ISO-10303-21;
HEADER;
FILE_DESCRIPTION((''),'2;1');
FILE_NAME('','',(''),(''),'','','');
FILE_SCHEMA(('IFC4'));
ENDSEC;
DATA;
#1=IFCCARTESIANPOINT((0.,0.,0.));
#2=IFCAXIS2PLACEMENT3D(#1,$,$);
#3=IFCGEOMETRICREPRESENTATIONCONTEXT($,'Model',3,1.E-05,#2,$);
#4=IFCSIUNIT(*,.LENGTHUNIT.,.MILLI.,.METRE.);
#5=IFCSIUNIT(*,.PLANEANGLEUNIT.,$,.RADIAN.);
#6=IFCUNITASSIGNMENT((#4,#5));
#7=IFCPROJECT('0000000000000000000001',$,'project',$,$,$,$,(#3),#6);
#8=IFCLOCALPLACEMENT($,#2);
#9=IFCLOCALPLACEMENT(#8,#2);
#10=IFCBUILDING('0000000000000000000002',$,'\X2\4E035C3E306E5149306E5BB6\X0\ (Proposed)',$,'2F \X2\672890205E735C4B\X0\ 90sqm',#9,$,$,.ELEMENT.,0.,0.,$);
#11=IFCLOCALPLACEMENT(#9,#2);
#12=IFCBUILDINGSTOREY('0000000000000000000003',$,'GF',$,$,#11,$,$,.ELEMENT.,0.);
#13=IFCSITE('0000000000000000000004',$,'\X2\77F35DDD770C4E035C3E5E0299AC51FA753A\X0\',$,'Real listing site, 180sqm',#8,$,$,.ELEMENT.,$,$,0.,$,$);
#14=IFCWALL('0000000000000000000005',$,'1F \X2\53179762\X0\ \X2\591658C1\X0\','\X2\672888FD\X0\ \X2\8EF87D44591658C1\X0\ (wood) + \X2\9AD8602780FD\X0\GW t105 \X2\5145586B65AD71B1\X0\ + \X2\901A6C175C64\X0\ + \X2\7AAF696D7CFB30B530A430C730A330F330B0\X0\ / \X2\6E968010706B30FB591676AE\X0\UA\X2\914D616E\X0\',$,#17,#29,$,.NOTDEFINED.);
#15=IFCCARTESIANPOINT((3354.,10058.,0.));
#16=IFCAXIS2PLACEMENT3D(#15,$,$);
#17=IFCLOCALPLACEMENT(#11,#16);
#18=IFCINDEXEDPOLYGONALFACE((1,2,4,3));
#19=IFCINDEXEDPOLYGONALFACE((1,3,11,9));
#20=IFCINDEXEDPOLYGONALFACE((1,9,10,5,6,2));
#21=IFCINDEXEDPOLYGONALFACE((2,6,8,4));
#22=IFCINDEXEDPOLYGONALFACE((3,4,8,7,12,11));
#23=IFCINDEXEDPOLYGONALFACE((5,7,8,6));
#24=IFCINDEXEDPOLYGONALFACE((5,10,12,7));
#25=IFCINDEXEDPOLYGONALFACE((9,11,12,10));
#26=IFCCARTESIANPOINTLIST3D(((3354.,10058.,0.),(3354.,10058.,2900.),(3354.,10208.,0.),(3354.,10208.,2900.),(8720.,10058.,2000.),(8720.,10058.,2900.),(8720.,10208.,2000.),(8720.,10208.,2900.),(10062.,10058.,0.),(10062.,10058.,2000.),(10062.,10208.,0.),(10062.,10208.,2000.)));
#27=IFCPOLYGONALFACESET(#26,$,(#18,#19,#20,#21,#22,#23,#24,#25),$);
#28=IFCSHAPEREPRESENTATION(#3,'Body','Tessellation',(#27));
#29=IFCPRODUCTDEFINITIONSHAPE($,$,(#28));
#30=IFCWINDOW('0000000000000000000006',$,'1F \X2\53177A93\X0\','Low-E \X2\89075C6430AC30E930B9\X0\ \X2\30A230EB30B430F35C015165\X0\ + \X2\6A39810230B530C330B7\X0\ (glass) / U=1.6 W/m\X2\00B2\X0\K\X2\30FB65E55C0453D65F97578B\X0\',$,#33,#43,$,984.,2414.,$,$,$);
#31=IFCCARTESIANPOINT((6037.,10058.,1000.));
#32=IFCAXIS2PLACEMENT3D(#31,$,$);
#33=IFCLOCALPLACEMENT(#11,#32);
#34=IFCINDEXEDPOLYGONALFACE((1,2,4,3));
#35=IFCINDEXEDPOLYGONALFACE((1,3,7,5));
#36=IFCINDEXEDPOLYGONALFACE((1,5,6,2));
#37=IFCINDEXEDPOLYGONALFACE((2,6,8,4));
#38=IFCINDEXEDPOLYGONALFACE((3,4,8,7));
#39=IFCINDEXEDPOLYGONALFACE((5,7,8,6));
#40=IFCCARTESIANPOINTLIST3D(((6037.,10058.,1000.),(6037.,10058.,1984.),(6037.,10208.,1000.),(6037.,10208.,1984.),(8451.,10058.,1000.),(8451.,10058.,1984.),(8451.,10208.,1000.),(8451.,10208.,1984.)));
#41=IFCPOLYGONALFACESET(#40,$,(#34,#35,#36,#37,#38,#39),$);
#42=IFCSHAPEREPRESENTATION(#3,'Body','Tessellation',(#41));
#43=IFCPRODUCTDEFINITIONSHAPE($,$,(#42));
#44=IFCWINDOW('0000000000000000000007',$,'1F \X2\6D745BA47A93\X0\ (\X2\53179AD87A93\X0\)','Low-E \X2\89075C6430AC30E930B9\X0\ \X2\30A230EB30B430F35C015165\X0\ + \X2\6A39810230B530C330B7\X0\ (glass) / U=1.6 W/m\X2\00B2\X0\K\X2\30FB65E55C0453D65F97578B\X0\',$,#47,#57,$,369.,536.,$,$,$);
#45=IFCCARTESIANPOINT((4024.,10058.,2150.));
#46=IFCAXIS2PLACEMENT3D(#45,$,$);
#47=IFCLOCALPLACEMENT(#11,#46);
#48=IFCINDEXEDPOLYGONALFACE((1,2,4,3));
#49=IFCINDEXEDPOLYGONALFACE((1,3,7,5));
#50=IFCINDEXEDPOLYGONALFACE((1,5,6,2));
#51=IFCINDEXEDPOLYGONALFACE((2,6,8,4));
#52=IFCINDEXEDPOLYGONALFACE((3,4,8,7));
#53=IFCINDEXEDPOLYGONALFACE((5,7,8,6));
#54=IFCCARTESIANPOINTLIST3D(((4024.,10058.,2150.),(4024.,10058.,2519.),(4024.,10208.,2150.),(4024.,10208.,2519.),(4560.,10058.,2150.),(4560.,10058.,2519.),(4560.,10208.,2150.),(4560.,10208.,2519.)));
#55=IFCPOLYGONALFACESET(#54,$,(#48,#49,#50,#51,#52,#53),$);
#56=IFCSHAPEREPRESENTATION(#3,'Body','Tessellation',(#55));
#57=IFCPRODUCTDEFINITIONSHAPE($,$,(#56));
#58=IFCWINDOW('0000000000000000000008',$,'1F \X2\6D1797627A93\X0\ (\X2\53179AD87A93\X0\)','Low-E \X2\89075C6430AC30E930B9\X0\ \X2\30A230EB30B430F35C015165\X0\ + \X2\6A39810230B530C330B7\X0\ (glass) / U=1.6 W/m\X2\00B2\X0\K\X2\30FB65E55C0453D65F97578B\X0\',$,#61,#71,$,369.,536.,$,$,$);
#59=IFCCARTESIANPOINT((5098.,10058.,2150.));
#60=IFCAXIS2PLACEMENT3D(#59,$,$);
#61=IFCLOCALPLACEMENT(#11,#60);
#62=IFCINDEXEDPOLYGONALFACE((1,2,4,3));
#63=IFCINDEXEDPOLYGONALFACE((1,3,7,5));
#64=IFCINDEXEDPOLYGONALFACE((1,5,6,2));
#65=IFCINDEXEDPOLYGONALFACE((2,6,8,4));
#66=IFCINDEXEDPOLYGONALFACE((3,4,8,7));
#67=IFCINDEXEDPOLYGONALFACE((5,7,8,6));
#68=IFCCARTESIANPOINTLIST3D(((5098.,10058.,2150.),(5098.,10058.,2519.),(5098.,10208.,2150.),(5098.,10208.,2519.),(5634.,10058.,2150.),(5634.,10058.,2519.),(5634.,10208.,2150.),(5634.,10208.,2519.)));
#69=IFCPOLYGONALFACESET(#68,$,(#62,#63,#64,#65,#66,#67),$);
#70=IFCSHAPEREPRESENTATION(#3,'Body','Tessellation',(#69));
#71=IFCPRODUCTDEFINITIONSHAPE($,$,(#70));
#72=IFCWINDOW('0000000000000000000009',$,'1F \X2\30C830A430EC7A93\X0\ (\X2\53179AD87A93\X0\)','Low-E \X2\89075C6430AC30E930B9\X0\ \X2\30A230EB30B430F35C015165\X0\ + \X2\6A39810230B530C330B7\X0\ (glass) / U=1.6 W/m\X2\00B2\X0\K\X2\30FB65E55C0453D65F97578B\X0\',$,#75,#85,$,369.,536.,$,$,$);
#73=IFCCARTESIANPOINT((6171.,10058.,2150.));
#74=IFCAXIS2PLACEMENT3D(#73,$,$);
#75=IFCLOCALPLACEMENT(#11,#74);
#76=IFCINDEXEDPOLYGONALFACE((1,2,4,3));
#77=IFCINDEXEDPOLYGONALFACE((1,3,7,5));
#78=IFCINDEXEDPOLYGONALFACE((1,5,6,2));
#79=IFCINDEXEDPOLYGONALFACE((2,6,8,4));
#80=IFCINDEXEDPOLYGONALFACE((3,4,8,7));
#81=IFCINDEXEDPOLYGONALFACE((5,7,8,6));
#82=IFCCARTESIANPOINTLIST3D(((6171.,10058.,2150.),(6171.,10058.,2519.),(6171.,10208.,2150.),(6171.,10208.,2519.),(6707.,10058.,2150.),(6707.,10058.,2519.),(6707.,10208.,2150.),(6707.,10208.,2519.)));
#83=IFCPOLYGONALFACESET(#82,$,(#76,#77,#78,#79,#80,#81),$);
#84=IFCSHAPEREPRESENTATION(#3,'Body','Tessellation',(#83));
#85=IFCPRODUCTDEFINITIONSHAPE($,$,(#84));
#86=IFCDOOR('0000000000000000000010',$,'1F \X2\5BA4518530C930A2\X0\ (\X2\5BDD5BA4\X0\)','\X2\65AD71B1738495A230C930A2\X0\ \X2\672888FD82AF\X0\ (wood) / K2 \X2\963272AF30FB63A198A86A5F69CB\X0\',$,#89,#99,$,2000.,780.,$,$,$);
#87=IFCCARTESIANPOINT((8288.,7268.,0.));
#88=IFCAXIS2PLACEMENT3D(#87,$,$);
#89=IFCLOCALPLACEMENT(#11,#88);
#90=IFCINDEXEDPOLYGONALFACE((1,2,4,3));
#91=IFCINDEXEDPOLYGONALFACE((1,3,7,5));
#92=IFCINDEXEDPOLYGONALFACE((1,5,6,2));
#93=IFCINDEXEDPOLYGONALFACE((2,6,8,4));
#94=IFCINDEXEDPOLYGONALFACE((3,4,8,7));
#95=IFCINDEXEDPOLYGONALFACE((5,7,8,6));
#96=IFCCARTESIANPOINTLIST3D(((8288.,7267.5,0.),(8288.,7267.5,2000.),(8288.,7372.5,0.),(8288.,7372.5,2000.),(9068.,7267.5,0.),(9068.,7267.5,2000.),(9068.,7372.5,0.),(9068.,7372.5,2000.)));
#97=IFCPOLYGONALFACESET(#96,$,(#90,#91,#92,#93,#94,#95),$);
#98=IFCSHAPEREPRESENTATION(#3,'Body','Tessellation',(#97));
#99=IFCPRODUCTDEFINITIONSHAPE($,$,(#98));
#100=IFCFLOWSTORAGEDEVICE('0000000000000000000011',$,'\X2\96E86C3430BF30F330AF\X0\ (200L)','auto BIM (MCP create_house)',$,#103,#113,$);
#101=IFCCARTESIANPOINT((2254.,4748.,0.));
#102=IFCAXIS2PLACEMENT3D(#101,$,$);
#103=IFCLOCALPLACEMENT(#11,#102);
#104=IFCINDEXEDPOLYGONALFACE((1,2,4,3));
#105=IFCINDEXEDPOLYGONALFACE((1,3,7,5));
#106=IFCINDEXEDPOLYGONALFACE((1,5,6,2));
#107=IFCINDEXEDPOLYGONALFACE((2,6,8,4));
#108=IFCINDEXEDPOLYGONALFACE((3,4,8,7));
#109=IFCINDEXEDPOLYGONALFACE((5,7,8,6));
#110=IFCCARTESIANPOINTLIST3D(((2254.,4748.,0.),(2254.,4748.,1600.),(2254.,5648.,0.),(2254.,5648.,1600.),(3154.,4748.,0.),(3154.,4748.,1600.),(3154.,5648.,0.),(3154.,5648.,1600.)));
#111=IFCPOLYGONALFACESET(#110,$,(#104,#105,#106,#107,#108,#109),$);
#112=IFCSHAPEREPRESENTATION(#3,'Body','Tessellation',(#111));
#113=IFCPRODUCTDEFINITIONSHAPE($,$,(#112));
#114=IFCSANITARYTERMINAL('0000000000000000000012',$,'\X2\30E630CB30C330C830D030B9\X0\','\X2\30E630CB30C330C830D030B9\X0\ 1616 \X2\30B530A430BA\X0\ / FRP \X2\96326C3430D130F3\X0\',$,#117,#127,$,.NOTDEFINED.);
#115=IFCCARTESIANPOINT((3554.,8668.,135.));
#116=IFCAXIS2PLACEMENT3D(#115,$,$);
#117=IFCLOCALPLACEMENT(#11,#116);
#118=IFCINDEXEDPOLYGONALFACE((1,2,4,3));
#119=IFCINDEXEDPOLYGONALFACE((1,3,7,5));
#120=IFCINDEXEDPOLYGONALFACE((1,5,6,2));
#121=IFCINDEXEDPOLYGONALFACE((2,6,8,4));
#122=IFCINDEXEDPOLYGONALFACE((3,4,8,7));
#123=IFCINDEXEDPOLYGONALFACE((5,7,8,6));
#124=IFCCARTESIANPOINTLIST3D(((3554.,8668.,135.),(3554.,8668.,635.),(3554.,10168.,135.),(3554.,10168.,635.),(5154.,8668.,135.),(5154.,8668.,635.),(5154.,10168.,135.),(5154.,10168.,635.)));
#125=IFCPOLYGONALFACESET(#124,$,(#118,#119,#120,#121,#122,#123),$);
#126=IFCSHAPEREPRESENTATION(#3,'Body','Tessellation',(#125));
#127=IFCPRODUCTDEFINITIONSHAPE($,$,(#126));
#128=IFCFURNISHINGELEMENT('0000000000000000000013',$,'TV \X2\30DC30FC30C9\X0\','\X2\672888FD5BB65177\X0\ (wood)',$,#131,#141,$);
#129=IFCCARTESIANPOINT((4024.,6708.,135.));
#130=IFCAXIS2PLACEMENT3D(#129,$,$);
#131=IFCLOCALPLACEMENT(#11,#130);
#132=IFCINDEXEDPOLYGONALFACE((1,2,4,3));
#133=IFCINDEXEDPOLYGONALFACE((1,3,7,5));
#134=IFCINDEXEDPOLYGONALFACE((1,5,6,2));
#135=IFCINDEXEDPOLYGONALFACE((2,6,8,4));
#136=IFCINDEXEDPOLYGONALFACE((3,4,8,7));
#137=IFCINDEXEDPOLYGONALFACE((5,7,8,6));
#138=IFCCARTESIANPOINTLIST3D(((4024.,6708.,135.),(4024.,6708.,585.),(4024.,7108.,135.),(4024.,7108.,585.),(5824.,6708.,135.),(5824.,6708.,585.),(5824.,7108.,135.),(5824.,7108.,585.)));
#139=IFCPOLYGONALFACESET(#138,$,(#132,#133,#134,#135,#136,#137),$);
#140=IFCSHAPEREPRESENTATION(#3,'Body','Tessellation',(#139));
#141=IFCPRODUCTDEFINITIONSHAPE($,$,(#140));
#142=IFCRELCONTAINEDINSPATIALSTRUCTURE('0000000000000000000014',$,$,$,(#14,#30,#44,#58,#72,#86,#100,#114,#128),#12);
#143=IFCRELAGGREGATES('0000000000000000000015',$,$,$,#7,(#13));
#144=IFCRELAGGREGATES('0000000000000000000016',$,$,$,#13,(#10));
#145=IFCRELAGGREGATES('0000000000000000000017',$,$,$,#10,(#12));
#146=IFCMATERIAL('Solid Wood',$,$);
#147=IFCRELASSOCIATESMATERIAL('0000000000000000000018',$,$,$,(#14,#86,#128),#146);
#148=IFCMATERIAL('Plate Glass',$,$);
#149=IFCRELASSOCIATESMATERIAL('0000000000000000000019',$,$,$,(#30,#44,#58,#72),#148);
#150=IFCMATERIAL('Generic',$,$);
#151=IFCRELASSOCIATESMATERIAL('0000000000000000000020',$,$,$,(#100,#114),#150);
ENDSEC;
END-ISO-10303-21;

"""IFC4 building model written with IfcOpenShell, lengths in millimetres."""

from ifc_helpers import new_model, si_unit, frame, frame_2d, origin, place, context, project, spatial, rectangle, extrude, material, element, fill, save


model = new_model("IFC4")

# Units and contexts
model_context = context("Model", 3, precision=1e-05, world=origin())
ifc_project = project(units=[si_unit("LENGTHUNIT", "METRE", prefix="MILLI"), si_unit("PLANEANGLEUNIT", "RADIAN")], contexts=[model_context])

# Site, building, storey
site_placement = place(None, origin())
site = spatial("IfcSite", under=ifc_project, at=site_placement, Name="石川県七尾市馬出町", ObjectType="Real listing site, 180sqm", CompositionType="ELEMENT", RefElevation=0.0)
building_placement = place(site_placement, origin())
building = spatial("IfcBuilding", under=site, at=building_placement, Name="七尾の光の家 (Proposed)", ObjectType="2F 木造平屋 90sqm", CompositionType="ELEMENT", ElevationOfRefHeight=0.0, ElevationOfTerrain=0.0)
storey_placement = place(building_placement, origin())
storey = spatial("IfcBuildingStorey", under=building, at=storey_placement, Name="GF", CompositionType="ELEMENT", Elevation=0.0)

# Wall, openings, windows
ifc_material_1 = material(Name="Solid Wood")
wall_1_placement = place(storey_placement, frame((3354.0, 10058.0, 0.0)))
wall_1 = element("IfcWall", 1, at=wall_1_placement, inside=storey, material=ifc_material_1, Name="1F 北面 外壁", Description="木製 軸組外壁 (wood) + 高性能GW t105 充填断熱 + 通気層 + 窯業系サイディング / 準耐火・外皮UA配慮", PredefinedType="NOTDEFINED", context=model_context, shape_type="SweptSolid", body=[
    extrude(rectangle(XDim=6708.0, YDim=150.0, at=frame_2d((3354.0, 75.0))), frame((3354.0, 10058.0, 0.0)), (0.0, 0.0, 1.0), 2900.0),
])
opening_1_placement = place(storey_placement, frame((6037.0, 10058.0, 1000.0)))
opening_1 = element("IfcOpeningElement", 2, at=opening_1_placement, cuts=wall_1, PredefinedType="NOTDEFINED", context=model_context, shape_type="SweptSolid", body=[
    extrude(rectangle(XDim=2414.0, YDim=150.0, at=frame_2d((1207.0, 75.0))), frame((6037.0, 10058.0, 1000.0)), (0.0, 0.0, 1.0), 984.0),
])
opening_2_placement = place(storey_placement, frame((4024.0, 10058.0, 2150.0)))
opening_2 = element("IfcOpeningElement", 3, at=opening_2_placement, cuts=wall_1, PredefinedType="NOTDEFINED", context=model_context, shape_type="SweptSolid", body=[
    extrude(rectangle(XDim=536.0, YDim=150.0, at=frame_2d((268.0, 75.0))), frame((4024.0, 10058.0, 2150.0)), (0.0, 0.0, 1.0), 369.0),
])
opening_3_placement = place(storey_placement, frame((5098.0, 10058.0, 2150.0)))
opening_3 = element("IfcOpeningElement", 4, at=opening_3_placement, cuts=wall_1, PredefinedType="NOTDEFINED", context=model_context, shape_type="SweptSolid", body=[
    extrude(rectangle(XDim=536.0, YDim=150.0, at=frame_2d((268.0, 75.0))), frame((5098.0, 10058.0, 2150.0)), (0.0, 0.0, 1.0), 369.0),
])
opening_4_placement = place(storey_placement, frame((6171.0, 10058.0, 2150.0)))
opening_4 = element("IfcOpeningElement", 5, at=opening_4_placement, cuts=wall_1, PredefinedType="NOTDEFINED", context=model_context, shape_type="SweptSolid", body=[
    extrude(rectangle(XDim=536.0, YDim=150.0, at=frame_2d((268.0, 75.0))), frame((6171.0, 10058.0, 2150.0)), (0.0, 0.0, 1.0), 369.0),
])
ifc_material_2 = material(Name="Plate Glass")
window_1_placement = place(storey_placement, frame((6037.0, 10058.0, 1000.0)))
window_1 = element("IfcWindow", 6, at=window_1_placement, inside=storey, material=ifc_material_2, Name="1F 北窓", Description="Low-E 複層ガラス アルゴン封入 + 樹脂サッシ (glass) / U=1.6 W/m²K・日射取得型", OverallHeight=984.0, OverallWidth=2414.0, context=model_context, shape_type="SweptSolid", body=[
    extrude(rectangle(XDim=2414.0, YDim=150.0, at=frame_2d((1207.0, 75.0))), frame((6037.0, 10058.0, 1000.0)), (0.0, 0.0, 1.0), 984.0),
])
fill(opening_1, window_1)
window_2_placement = place(storey_placement, frame((4024.0, 10058.0, 2150.0)))
window_2 = element("IfcWindow", 7, at=window_2_placement, inside=storey, material=ifc_material_2, Name="1F 浴室窓 (北高窓)", Description="Low-E 複層ガラス アルゴン封入 + 樹脂サッシ (glass) / U=1.6 W/m²K・日射取得型", OverallHeight=369.0, OverallWidth=536.0, context=model_context, shape_type="SweptSolid", body=[
    extrude(rectangle(XDim=536.0, YDim=150.0, at=frame_2d((268.0, 75.0))), frame((4024.0, 10058.0, 2150.0)), (0.0, 0.0, 1.0), 369.0),
])
fill(opening_2, window_2)
window_3_placement = place(storey_placement, frame((5098.0, 10058.0, 2150.0)))
window_3 = element("IfcWindow", 8, at=window_3_placement, inside=storey, material=ifc_material_2, Name="1F 洗面窓 (北高窓)", Description="Low-E 複層ガラス アルゴン封入 + 樹脂サッシ (glass) / U=1.6 W/m²K・日射取得型", OverallHeight=369.0, OverallWidth=536.0, context=model_context, shape_type="SweptSolid", body=[
    extrude(rectangle(XDim=536.0, YDim=150.0, at=frame_2d((268.0, 75.0))), frame((5098.0, 10058.0, 2150.0)), (0.0, 0.0, 1.0), 369.0),
])
fill(opening_3, window_3)
window_4_placement = place(storey_placement, frame((6171.0, 10058.0, 2150.0)))
window_4 = element("IfcWindow", 9, at=window_4_placement, inside=storey, material=ifc_material_2, Name="1F トイレ窓 (北高窓)", Description="Low-E 複層ガラス アルゴン封入 + 樹脂サッシ (glass) / U=1.6 W/m²K・日射取得型", OverallHeight=369.0, OverallWidth=536.0, context=model_context, shape_type="SweptSolid", body=[
    extrude(rectangle(XDim=536.0, YDim=150.0, at=frame_2d((268.0, 75.0))), frame((6171.0, 10058.0, 2150.0)), (0.0, 0.0, 1.0), 369.0),
])
fill(opening_4, window_4)

# Door
door_1_placement = place(storey_placement, frame((8288.0, 7268.0, 0.0)))
element("IfcDoor", 10, at=door_1_placement, inside=storey, material=ifc_material_1, Name="1F 室内ドア (寝室)", Description="断熱玄関ドア 木製芯 (wood) / K2 防犯・採風機構", OverallHeight=2000.0, OverallWidth=780.0, context=model_context, shape_type="SweptSolid", body=[
    extrude(rectangle(XDim=780.0, YDim=105.0, at=frame_2d((390.0, 52.0))), frame((8288.0, 7268.0, 0.0)), (0.0, 0.0, 1.0), 2000.0),
])

# Flow storage device
ifc_material_3 = material(Name="Generic")
flow_storage_device_placement = place(storey_placement, frame((2254.0, 4748.0, 0.0)))
element("IfcFlowStorageDevice", 11, at=flow_storage_device_placement, inside=storey, material=ifc_material_3, Name="雨水タンク (200L)", Description="auto BIM (MCP create_house)", context=model_context, shape_type="SweptSolid", body=[
    extrude(rectangle(XDim=900.0, YDim=900.0, at=frame_2d((450.0, 450.0))), frame((2254.0, 4748.0, 0.0)), (0.0, 0.0, 1.0), 1600.0),
])

# Sanitary terminal
sanitary_terminal_placement = place(storey_placement, frame((3554.0, 8668.0, 135.0)))
element("IfcSanitaryTerminal", 12, at=sanitary_terminal_placement, inside=storey, material=ifc_material_3, Name="ユニットバス", Description="ユニットバス 1616 サイズ / FRP 防水パン", PredefinedType="NOTDEFINED", context=model_context, shape_type="SweptSolid", body=[
    extrude(rectangle(XDim=1600.0, YDim=1500.0, at=frame_2d((800.0, 750.0))), frame((3554.0, 8668.0, 135.0)), (0.0, 0.0, 1.0), 500.0),
])

# Furnishing element
furnishing_placement = place(storey_placement, frame((4024.0, 6708.0, 135.0)))
element("IfcFurnishingElement", 13, at=furnishing_placement, inside=storey, material=ifc_material_1, Name="TV ボード", Description="木製家具 (wood)", context=model_context, shape_type="SweptSolid", body=[
    extrude(rectangle(XDim=1800.0, YDim=400.0, at=frame_2d((900.0, 200.0))), frame((4024.0, 6708.0, 135.0)), (0.0, 0.0, 1.0), 450.0),
])

save(model, "model.ifc")
